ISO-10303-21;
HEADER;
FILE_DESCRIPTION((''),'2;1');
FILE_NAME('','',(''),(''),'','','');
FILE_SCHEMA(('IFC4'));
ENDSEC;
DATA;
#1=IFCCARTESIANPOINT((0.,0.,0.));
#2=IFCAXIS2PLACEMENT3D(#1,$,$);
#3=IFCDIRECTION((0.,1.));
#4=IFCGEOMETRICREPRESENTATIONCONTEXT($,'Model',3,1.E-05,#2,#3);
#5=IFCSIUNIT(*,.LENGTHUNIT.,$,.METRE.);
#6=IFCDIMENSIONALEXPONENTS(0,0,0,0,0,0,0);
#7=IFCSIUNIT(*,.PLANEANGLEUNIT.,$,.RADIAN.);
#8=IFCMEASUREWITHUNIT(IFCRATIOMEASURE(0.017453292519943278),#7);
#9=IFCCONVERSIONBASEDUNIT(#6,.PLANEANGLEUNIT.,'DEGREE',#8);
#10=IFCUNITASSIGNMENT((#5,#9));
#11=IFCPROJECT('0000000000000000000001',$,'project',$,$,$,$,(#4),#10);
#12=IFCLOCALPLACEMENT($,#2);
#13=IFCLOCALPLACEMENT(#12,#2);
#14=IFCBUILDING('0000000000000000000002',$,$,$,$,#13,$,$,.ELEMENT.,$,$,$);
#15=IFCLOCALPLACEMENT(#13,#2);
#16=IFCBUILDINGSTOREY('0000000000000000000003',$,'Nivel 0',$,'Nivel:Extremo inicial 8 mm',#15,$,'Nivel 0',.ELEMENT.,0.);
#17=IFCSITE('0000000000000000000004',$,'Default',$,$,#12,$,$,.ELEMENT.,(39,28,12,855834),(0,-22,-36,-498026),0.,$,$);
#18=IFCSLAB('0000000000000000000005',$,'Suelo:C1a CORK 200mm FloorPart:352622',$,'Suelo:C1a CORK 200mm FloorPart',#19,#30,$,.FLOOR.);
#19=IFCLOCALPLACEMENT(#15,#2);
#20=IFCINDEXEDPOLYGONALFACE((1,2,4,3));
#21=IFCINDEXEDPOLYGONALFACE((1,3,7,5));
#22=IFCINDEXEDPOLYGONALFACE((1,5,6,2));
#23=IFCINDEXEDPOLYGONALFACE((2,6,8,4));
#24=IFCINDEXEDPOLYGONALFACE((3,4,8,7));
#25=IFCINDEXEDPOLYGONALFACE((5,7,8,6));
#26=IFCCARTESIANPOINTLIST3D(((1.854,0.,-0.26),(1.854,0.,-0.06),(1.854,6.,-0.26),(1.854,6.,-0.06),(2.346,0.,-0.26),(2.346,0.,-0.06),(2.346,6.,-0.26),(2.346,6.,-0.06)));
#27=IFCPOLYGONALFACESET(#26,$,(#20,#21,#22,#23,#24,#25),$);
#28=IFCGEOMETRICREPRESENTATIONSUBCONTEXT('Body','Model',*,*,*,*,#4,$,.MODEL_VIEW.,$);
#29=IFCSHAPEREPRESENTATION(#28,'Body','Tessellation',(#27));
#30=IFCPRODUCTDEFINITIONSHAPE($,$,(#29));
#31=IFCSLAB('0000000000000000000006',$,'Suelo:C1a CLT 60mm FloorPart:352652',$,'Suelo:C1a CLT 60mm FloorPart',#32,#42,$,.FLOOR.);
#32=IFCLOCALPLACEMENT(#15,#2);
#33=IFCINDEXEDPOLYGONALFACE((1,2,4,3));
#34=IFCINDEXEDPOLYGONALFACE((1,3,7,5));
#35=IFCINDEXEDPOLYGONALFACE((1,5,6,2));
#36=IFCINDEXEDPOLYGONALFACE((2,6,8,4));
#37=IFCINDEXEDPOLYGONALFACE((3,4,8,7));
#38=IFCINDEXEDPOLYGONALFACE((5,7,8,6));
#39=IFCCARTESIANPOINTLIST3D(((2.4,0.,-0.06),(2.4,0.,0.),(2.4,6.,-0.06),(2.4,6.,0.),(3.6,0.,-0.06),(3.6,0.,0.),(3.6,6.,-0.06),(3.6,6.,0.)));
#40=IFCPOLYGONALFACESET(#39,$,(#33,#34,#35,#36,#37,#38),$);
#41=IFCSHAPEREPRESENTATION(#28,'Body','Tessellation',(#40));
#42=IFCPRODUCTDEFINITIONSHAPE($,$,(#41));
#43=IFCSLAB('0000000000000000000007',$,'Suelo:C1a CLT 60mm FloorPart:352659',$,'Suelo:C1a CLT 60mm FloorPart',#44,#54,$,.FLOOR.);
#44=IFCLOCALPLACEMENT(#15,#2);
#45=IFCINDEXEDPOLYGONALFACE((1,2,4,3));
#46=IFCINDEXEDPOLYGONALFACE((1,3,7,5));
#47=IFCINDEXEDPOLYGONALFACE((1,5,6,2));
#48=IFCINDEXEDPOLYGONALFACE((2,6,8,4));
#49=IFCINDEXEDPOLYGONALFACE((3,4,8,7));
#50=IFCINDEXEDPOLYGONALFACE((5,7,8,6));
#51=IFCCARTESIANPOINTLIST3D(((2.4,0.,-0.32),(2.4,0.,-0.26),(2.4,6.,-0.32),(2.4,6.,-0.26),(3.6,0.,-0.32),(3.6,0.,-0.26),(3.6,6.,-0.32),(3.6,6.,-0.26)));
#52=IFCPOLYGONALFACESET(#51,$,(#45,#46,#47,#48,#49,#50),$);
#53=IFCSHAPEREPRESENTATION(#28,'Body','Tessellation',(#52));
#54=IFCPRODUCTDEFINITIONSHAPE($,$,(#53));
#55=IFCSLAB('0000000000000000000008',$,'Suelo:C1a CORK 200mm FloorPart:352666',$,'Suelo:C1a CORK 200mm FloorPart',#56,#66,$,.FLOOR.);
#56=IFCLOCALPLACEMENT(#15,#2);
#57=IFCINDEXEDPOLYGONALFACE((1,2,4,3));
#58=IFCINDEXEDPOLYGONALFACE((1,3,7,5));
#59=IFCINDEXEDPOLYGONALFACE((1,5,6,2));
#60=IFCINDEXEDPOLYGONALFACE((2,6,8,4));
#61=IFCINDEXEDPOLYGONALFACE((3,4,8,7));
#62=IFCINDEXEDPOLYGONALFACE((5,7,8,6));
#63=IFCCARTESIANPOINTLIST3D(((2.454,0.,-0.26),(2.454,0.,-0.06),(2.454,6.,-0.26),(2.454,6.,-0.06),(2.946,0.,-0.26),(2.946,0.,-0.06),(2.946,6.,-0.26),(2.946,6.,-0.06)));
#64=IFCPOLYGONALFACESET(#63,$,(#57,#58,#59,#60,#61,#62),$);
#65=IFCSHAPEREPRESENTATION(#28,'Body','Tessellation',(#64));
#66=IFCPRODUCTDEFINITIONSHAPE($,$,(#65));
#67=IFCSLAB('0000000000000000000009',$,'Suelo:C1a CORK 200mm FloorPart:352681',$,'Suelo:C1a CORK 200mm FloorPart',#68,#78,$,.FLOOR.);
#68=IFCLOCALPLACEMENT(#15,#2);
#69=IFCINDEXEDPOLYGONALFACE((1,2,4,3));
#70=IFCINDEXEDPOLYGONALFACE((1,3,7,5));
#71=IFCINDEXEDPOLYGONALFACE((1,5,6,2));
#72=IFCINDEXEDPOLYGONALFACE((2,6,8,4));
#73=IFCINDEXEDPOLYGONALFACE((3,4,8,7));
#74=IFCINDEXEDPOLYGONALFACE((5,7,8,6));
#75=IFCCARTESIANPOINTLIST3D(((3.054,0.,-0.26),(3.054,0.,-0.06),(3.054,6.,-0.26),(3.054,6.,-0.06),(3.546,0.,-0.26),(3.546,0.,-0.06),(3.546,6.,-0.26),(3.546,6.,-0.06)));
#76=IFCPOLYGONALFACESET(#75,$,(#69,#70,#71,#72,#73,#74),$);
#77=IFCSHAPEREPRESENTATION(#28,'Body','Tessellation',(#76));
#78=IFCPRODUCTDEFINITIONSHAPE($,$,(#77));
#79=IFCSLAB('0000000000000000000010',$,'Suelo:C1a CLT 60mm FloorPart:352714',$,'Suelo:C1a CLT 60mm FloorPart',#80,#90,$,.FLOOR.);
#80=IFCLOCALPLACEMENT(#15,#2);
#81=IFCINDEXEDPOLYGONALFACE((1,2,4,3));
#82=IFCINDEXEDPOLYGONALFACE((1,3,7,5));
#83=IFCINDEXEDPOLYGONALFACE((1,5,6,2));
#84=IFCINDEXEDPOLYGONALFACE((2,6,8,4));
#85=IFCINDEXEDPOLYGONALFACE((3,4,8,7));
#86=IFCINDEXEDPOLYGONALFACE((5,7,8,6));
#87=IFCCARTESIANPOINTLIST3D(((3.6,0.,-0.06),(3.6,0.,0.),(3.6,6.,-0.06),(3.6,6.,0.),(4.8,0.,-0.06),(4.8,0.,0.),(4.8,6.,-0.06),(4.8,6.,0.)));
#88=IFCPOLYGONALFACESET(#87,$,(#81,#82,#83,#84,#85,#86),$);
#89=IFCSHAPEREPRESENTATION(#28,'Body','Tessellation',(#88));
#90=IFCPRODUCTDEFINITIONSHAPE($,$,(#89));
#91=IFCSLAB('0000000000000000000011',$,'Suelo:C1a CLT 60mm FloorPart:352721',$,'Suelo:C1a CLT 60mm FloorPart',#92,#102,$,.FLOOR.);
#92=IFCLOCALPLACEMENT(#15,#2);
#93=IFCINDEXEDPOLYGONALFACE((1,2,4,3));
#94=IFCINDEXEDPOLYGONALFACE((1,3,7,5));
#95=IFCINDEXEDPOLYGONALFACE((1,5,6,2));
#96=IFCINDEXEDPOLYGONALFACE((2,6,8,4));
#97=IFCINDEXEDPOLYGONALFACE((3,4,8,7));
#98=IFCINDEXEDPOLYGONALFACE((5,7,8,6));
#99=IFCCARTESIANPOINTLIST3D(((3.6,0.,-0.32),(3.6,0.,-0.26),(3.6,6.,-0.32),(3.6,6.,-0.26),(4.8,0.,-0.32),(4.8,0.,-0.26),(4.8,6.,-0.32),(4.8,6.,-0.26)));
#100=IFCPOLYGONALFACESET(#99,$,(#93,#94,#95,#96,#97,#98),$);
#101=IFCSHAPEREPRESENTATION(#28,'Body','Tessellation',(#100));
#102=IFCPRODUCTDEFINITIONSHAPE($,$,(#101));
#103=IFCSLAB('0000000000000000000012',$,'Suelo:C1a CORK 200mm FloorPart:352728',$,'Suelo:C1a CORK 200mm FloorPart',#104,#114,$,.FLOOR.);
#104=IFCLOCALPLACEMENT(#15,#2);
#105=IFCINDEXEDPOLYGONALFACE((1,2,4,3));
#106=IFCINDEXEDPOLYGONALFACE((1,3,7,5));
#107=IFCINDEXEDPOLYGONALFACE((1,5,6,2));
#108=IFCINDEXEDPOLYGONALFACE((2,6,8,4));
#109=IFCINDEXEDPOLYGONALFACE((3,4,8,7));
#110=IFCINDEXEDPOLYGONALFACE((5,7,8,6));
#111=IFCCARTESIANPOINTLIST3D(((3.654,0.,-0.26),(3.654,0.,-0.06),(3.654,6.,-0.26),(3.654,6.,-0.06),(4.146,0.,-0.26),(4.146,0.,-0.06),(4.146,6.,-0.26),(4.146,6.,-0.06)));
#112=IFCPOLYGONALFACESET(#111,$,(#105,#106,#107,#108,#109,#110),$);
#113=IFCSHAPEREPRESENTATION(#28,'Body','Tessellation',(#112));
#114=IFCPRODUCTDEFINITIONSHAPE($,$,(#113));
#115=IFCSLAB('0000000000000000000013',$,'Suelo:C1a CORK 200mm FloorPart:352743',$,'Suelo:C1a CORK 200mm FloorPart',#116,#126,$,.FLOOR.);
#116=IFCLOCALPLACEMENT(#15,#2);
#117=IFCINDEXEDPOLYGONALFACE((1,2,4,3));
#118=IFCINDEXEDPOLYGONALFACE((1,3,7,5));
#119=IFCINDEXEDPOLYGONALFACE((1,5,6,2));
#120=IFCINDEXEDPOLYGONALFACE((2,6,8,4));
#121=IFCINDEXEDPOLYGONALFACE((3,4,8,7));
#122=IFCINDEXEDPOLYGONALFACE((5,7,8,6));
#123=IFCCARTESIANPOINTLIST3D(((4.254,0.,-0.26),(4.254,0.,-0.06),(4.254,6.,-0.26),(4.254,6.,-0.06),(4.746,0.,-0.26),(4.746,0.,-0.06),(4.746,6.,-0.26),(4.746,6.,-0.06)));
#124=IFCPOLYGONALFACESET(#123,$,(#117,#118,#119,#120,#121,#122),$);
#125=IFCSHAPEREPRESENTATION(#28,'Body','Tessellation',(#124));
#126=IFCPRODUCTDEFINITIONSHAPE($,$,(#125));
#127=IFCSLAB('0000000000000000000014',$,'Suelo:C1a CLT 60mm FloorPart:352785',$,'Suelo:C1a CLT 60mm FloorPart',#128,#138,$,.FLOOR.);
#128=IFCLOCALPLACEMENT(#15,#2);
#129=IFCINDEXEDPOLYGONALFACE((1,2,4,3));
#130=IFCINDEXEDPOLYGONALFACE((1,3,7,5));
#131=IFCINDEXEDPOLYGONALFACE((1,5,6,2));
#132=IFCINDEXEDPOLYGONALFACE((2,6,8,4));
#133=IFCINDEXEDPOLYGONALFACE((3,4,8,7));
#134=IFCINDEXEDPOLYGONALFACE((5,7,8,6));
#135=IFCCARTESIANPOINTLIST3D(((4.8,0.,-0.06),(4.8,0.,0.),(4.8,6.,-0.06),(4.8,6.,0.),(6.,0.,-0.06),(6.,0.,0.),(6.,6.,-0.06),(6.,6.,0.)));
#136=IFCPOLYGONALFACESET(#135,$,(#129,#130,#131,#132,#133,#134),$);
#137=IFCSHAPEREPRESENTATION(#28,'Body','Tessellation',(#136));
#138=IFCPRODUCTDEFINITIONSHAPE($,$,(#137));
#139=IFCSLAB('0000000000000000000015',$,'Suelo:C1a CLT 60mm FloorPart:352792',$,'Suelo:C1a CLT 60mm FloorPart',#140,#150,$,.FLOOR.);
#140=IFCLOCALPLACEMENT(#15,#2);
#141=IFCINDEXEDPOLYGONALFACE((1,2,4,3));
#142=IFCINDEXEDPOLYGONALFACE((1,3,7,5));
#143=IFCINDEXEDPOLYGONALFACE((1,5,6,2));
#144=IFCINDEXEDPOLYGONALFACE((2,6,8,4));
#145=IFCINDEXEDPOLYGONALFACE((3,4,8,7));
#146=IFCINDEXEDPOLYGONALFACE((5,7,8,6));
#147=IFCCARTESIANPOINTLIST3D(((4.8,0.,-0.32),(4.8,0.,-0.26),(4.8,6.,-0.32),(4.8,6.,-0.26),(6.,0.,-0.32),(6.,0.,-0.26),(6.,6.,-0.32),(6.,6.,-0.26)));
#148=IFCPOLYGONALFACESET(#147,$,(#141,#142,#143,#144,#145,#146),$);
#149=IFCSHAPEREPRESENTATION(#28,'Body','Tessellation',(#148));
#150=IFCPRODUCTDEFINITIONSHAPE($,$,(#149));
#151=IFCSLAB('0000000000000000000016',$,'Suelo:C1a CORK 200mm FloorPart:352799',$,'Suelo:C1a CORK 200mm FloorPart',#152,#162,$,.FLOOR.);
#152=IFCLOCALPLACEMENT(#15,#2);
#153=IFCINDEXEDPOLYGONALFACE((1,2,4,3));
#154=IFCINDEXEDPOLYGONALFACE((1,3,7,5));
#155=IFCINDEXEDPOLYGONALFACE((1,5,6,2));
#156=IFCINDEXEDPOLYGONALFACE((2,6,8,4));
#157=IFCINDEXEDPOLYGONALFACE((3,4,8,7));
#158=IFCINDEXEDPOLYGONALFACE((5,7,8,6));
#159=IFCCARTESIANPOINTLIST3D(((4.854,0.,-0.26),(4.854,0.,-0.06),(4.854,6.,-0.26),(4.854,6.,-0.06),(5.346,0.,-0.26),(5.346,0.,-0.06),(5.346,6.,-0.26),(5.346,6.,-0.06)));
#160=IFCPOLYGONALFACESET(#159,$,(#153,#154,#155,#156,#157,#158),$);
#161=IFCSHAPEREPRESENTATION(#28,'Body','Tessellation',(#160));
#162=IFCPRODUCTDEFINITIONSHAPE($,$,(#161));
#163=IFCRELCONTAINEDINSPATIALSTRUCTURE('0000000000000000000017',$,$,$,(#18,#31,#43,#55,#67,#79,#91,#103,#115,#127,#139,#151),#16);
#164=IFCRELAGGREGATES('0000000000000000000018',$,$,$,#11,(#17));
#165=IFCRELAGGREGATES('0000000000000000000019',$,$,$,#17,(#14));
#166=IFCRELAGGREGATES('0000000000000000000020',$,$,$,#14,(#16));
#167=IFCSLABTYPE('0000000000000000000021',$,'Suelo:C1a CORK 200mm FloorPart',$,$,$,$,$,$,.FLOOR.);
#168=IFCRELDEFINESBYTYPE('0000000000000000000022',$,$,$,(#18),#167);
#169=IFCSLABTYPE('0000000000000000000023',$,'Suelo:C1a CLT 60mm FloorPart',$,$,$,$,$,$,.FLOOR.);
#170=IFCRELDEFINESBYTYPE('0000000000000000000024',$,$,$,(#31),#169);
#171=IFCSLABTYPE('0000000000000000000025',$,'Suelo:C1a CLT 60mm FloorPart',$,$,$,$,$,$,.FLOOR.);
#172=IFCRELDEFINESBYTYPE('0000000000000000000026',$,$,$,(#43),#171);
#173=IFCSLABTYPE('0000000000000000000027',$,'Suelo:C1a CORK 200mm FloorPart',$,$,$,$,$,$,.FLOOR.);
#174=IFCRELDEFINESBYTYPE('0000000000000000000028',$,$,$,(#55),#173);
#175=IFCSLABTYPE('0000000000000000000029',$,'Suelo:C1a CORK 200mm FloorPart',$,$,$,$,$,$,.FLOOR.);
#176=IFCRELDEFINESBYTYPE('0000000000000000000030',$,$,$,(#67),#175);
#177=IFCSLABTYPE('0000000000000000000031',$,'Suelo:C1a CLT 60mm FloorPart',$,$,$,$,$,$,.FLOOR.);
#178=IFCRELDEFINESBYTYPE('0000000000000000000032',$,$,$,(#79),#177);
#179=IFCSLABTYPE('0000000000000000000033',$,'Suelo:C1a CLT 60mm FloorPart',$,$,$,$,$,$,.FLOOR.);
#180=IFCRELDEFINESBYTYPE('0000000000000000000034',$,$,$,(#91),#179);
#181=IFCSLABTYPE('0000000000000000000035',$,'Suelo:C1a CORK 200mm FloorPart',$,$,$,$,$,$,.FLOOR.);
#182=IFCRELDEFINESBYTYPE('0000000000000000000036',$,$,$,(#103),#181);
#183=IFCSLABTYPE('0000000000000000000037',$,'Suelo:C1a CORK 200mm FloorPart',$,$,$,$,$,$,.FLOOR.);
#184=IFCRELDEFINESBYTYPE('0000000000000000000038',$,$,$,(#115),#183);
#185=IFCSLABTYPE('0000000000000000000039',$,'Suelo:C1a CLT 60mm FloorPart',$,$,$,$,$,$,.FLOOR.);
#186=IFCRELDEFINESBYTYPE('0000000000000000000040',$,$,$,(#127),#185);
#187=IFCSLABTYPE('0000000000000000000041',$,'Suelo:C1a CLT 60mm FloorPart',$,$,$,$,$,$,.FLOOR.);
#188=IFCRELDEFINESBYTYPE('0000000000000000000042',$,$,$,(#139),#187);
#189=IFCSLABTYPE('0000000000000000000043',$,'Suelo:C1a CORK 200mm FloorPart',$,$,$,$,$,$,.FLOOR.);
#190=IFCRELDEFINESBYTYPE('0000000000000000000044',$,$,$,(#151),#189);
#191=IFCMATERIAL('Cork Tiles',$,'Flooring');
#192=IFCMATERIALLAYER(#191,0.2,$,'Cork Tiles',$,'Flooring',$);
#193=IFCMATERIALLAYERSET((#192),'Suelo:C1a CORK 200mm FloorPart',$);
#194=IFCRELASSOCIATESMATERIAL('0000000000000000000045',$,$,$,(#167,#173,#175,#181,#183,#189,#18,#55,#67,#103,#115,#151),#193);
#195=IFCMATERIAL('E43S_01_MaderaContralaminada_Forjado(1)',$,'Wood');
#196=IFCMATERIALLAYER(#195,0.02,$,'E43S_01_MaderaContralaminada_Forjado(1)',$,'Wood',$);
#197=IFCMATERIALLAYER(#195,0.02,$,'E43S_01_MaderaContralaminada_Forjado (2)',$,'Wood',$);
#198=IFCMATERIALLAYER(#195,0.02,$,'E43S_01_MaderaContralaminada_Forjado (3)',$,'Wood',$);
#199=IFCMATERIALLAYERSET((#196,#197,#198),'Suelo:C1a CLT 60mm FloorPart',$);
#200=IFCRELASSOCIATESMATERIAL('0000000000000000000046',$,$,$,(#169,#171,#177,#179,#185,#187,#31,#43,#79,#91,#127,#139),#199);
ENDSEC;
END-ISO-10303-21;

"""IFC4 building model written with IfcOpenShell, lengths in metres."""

from ifc_helpers import new_model, entity, si_unit, converted_unit, direction, frame, frame_2d, origin, place, context, subcontext, project, spatial, rectangle, extrude, material, layer, layer_set, layer_usage, type_object, element, save


model = new_model("IFC4")

# Units and contexts
model_context = context("Model", 3, precision=1e-05, world=origin(), true_north=direction((0.0, 1.0)))
body_context = subcontext(model_context, "Body", "Model", "MODEL_VIEW")
ifc_project = project(units=[si_unit("LENGTHUNIT", "METRE"), converted_unit("PLANEANGLEUNIT", "DEGREE", entity("IfcRatioMeasure", 0.017453292519943278), si_unit("PLANEANGLEUNIT", "RADIAN"), dimensions=[0, 0, 0, 0, 0, 0, 0])], contexts=[model_context])

# Site, building, storey
site_placement = place(None, origin())
site = spatial("IfcSite", under=ifc_project, at=site_placement, Name="Default", CompositionType="ELEMENT", RefLatitude=(39, 28, 12, 855834), RefLongitude=(0, -22, -36, -498026), RefElevation=0.0)
building_placement = place(site_placement, origin())
building = spatial("IfcBuilding", under=site, at=building_placement, CompositionType="ELEMENT")
storey_placement = place(building_placement, origin())
storey = spatial("IfcBuildingStorey", under=building, at=storey_placement, Name="Nivel 0", ObjectType="Nivel:Extremo inicial 8 mm", LongName="Nivel 0", CompositionType="ELEMENT", Elevation=0.0)

# Slabs
ifc_material_1 = material(Name="E43S_01_MaderaContralaminada_Forjado(1)", Category="Wood")
ifc_layer_1 = layer(ifc_material_1, 0.02, Name="E43S_01_MaderaContralaminada_Forjado(1)", Category="Wood")
ifc_layer_2 = layer(ifc_material_1, 0.02, Name="E43S_01_MaderaContralaminada_Forjado (2)", Category="Wood")
ifc_layer_3 = layer(ifc_material_1, 0.02, Name="E43S_01_MaderaContralaminada_Forjado (3)", Category="Wood")
ifc_layer_set_1 = layer_set([ifc_layer_1, ifc_layer_2, ifc_layer_3], Name="Suelo:C1a CLT 60mm FloorPart")
ifc_material_2 = material(Name="Cork Tiles", Category="Flooring")
ifc_layer_4 = layer(ifc_material_2, 0.2, Name="Cork Tiles", Category="Flooring")
ifc_layer_set_2 = layer_set([ifc_layer_4], Name="Suelo:C1a CORK 200mm FloorPart")
ifc_layer_usage_1 = layer_usage(ifc_layer_set_2, "AXIS3", "POSITIVE", 0.0)
slab_type_1 = type_object("IfcSlabType", Name="Suelo:C1a CORK 200mm FloorPart", PredefinedType="FLOOR", material=ifc_layer_set_2)
slab_1_placement = place(storey_placement, origin())
element("IfcSlab", 1, at=slab_1_placement, inside=storey, type_object=slab_type_1, material=ifc_layer_usage_1, Name="Suelo:C1a CORK 200mm FloorPart:352622", ObjectType="Suelo:C1a CORK 200mm FloorPart", PredefinedType="FLOOR", context=body_context, shape_type="SweptSolid", body=[
    extrude(rectangle(XDim=6.0, YDim=0.492, at=frame_2d((0.0, 0.0), x_axis=(1.0, 0.0))), frame((2.1, 3.0, -0.06), z_axis=(0.0, 0.0, -1.0), x_axis=(0.0, 1.0, 0.0)), (0.0, 0.0, 1.0), 0.2),
])
ifc_layer_usage_2 = layer_usage(ifc_layer_set_1, "AXIS3", "POSITIVE", 0.0)
slab_type_2 = type_object("IfcSlabType", Name="Suelo:C1a CLT 60mm FloorPart", PredefinedType="FLOOR", material=ifc_layer_set_1)
slab_2_placement = place(storey_placement, origin())
element("IfcSlab", 2, at=slab_2_placement, inside=storey, type_object=slab_type_2, material=ifc_layer_usage_2, Name="Suelo:C1a CLT 60mm FloorPart:352652", ObjectType="Suelo:C1a CLT 60mm FloorPart", PredefinedType="FLOOR", context=body_context, shape_type="SweptSolid", body=[
    extrude(rectangle(XDim=6.0, YDim=1.2, at=frame_2d((0.0, 0.0), x_axis=(1.0, 0.0))), frame((3.0, 3.0, 0.0), z_axis=(0.0, 0.0, -1.0), x_axis=(0.0, 1.0, 0.0)), (0.0, 0.0, 1.0), 0.06),
])
ifc_layer_usage_3 = layer_usage(ifc_layer_set_1, "AXIS3", "POSITIVE", 0.0)
slab_type_3 = type_object("IfcSlabType", Name="Suelo:C1a CLT 60mm FloorPart", PredefinedType="FLOOR", material=ifc_layer_set_1)
slab_3_placement = place(storey_placement, origin())
element("IfcSlab", 3, at=slab_3_placement, inside=storey, type_object=slab_type_3, material=ifc_layer_usage_3, Name="Suelo:C1a CLT 60mm FloorPart:352659", ObjectType="Suelo:C1a CLT 60mm FloorPart", PredefinedType="FLOOR", context=body_context, shape_type="SweptSolid", body=[
    extrude(rectangle(XDim=6.0, YDim=1.2, at=frame_2d((0.0, 0.0), x_axis=(1.0, 0.0))), frame((3.0, 3.0, -0.26), z_axis=(0.0, 0.0, -1.0), x_axis=(0.0, 1.0, 0.0)), (0.0, 0.0, 1.0), 0.06),
])
ifc_layer_usage_4 = layer_usage(ifc_layer_set_2, "AXIS3", "POSITIVE", 0.0)
slab_type_4 = type_object("IfcSlabType", Name="Suelo:C1a CORK 200mm FloorPart", PredefinedType="FLOOR", material=ifc_layer_set_2)
slab_4_placement = place(storey_placement, origin())
element("IfcSlab", 4, at=slab_4_placement, inside=storey, type_object=slab_type_4, material=ifc_layer_usage_4, Name="Suelo:C1a CORK 200mm FloorPart:352666", ObjectType="Suelo:C1a CORK 200mm FloorPart", PredefinedType="FLOOR", context=body_context, shape_type="SweptSolid", body=[
    extrude(rectangle(XDim=6.0, YDim=0.492, at=frame_2d((0.0, 0.0), x_axis=(1.0, 0.0))), frame((2.7, 3.0, -0.06), z_axis=(0.0, 0.0, -1.0), x_axis=(0.0, 1.0, 0.0)), (0.0, 0.0, 1.0), 0.2),
])
ifc_layer_usage_5 = layer_usage(ifc_layer_set_2, "AXIS3", "POSITIVE", 0.0)
slab_type_5 = type_object("IfcSlabType", Name="Suelo:C1a CORK 200mm FloorPart", PredefinedType="FLOOR", material=ifc_layer_set_2)
slab_5_placement = place(storey_placement, origin())
element("IfcSlab", 5, at=slab_5_placement, inside=storey, type_object=slab_type_5, material=ifc_layer_usage_5, Name="Suelo:C1a CORK 200mm FloorPart:352681", ObjectType="Suelo:C1a CORK 200mm FloorPart", PredefinedType="FLOOR", context=body_context, shape_type="SweptSolid", body=[
    extrude(rectangle(XDim=6.0, YDim=0.492, at=frame_2d((0.0, 0.0), x_axis=(1.0, 0.0))), frame((3.3, 3.0, -0.06), z_axis=(0.0, 0.0, -1.0), x_axis=(0.0, 1.0, 0.0)), (0.0, 0.0, 1.0), 0.2),
])
ifc_layer_usage_6 = layer_usage(ifc_layer_set_1, "AXIS3", "POSITIVE", 0.0)
slab_type_6 = type_object("IfcSlabType", Name="Suelo:C1a CLT 60mm FloorPart", PredefinedType="FLOOR", material=ifc_layer_set_1)
slab_6_placement = place(storey_placement, origin())
element("IfcSlab", 6, at=slab_6_placement, inside=storey, type_object=slab_type_6, material=ifc_layer_usage_6, Name="Suelo:C1a CLT 60mm FloorPart:352714", ObjectType="Suelo:C1a CLT 60mm FloorPart", PredefinedType="FLOOR", context=body_context, shape_type="SweptSolid", body=[
    extrude(rectangle(XDim=6.0, YDim=1.2, at=frame_2d((0.0, 0.0), x_axis=(1.0, 0.0))), frame((4.2, 3.0, 0.0), z_axis=(0.0, 0.0, -1.0), x_axis=(0.0, 1.0, 0.0)), (0.0, 0.0, 1.0), 0.06),
])
ifc_layer_usage_7 = layer_usage(ifc_layer_set_1, "AXIS3", "POSITIVE", 0.0)
slab_type_7 = type_object("IfcSlabType", Name="Suelo:C1a CLT 60mm FloorPart", PredefinedType="FLOOR", material=ifc_layer_set_1)
slab_7_placement = place(storey_placement, origin())
element("IfcSlab", 7, at=slab_7_placement, inside=storey, type_object=slab_type_7, material=ifc_layer_usage_7, Name="Suelo:C1a CLT 60mm FloorPart:352721", ObjectType="Suelo:C1a CLT 60mm FloorPart", PredefinedType="FLOOR", context=body_context, shape_type="SweptSolid", body=[
    extrude(rectangle(XDim=6.0, YDim=1.2, at=frame_2d((0.0, 0.0), x_axis=(1.0, 0.0))), frame((4.2, 3.0, -0.26), z_axis=(0.0, 0.0, -1.0), x_axis=(0.0, 1.0, 0.0)), (0.0, 0.0, 1.0), 0.06),
])
ifc_layer_usage_8 = layer_usage(ifc_layer_set_2, "AXIS3", "POSITIVE", 0.0)
slab_type_8 = type_object("IfcSlabType", Name="Suelo:C1a CORK 200mm FloorPart", PredefinedType="FLOOR", material=ifc_layer_set_2)
slab_8_placement = place(storey_placement, origin())
element("IfcSlab", 8, at=slab_8_placement, inside=storey, type_object=slab_type_8, material=ifc_layer_usage_8, Name="Suelo:C1a CORK 200mm FloorPart:352728", ObjectType="Suelo:C1a CORK 200mm FloorPart", PredefinedType="FLOOR", context=body_context, shape_type="SweptSolid", body=[
    extrude(rectangle(XDim=6.0, YDim=0.492, at=frame_2d((0.0, 0.0), x_axis=(1.0, 0.0))), frame((3.9, 3.0, -0.06), z_axis=(0.0, 0.0, -1.0), x_axis=(0.0, 1.0, 0.0)), (0.0, 0.0, 1.0), 0.2),
])
ifc_layer_usage_9 = layer_usage(ifc_layer_set_2, "AXIS3", "POSITIVE", 0.0)
slab_type_9 = type_object("IfcSlabType", Name="Suelo:C1a CORK 200mm FloorPart", PredefinedType="FLOOR", material=ifc_layer_set_2)
slab_9_placement = place(storey_placement, origin())
element("IfcSlab", 9, at=slab_9_placement, inside=storey, type_object=slab_type_9, material=ifc_layer_usage_9, Name="Suelo:C1a CORK 200mm FloorPart:352743", ObjectType="Suelo:C1a CORK 200mm FloorPart", PredefinedType="FLOOR", context=body_context, shape_type="SweptSolid", body=[
    extrude(rectangle(XDim=6.0, YDim=0.492, at=frame_2d((0.0, 0.0), x_axis=(1.0, 0.0))), frame((4.5, 3.0, -0.06), z_axis=(0.0, 0.0, -1.0), x_axis=(0.0, 1.0, 0.0)), (0.0, 0.0, 1.0), 0.2),
])
ifc_layer_usage_10 = layer_usage(ifc_layer_set_1, "AXIS3", "POSITIVE", 0.0)
slab_type_10 = type_object("IfcSlabType", Name="Suelo:C1a CLT 60mm FloorPart", PredefinedType="FLOOR", material=ifc_layer_set_1)
slab_10_placement = place(storey_placement, origin())
element("IfcSlab", 10, at=slab_10_placement, inside=storey, type_object=slab_type_10, material=ifc_layer_usage_10, Name="Suelo:C1a CLT 60mm FloorPart:352785", ObjectType="Suelo:C1a CLT 60mm FloorPart", PredefinedType="FLOOR", context=body_context, shape_type="SweptSolid", body=[
    extrude(rectangle(XDim=6.0, YDim=1.2, at=frame_2d((0.0, 0.0), x_axis=(1.0, 0.0))), frame((5.4, 3.0, 0.0), z_axis=(0.0, 0.0, -1.0), x_axis=(0.0, 1.0, 0.0)), (0.0, 0.0, 1.0), 0.06),
])
ifc_layer_usage_11 = layer_usage(ifc_layer_set_1, "AXIS3", "POSITIVE", 0.0)
slab_type_11 = type_object("IfcSlabType", Name="Suelo:C1a CLT 60mm FloorPart", PredefinedType="FLOOR", material=ifc_layer_set_1)
slab_11_placement = place(storey_placement, origin())
element("IfcSlab", 11, at=slab_11_placement, inside=storey, type_object=slab_type_11, material=ifc_layer_usage_11, Name="Suelo:C1a CLT 60mm FloorPart:352792", ObjectType="Suelo:C1a CLT 60mm FloorPart", PredefinedType="FLOOR", context=body_context, shape_type="SweptSolid", body=[
    extrude(rectangle(XDim=6.0, YDim=1.2, at=frame_2d((0.0, 0.0), x_axis=(1.0, 0.0))), frame((5.4, 3.0, -0.26), z_axis=(0.0, 0.0, -1.0), x_axis=(0.0, 1.0, 0.0)), (0.0, 0.0, 1.0), 0.06),
])
ifc_layer_usage_12 = layer_usage(ifc_layer_set_2, "AXIS3", "POSITIVE", 0.0)
slab_type_12 = type_object("IfcSlabType", Name="Suelo:C1a CORK 200mm FloorPart", PredefinedType="FLOOR", material=ifc_layer_set_2)
slab_12_placement = place(storey_placement, origin())
element("IfcSlab", 12, at=slab_12_placement, inside=storey, type_object=slab_type_12, material=ifc_layer_usage_12, Name="Suelo:C1a CORK 200mm FloorPart:352799", ObjectType="Suelo:C1a CORK 200mm FloorPart", PredefinedType="FLOOR", context=body_context, shape_type="SweptSolid", body=[
    extrude(rectangle(XDim=6.0, YDim=0.492, at=frame_2d((0.0, 0.0), x_axis=(1.0, 0.0))), frame((5.1, 3.0, -0.06), z_axis=(0.0, 0.0, -1.0), x_axis=(0.0, 1.0, 0.0)), (0.0, 0.0, 1.0), 0.2),
])

save(model, "model.ifc")
